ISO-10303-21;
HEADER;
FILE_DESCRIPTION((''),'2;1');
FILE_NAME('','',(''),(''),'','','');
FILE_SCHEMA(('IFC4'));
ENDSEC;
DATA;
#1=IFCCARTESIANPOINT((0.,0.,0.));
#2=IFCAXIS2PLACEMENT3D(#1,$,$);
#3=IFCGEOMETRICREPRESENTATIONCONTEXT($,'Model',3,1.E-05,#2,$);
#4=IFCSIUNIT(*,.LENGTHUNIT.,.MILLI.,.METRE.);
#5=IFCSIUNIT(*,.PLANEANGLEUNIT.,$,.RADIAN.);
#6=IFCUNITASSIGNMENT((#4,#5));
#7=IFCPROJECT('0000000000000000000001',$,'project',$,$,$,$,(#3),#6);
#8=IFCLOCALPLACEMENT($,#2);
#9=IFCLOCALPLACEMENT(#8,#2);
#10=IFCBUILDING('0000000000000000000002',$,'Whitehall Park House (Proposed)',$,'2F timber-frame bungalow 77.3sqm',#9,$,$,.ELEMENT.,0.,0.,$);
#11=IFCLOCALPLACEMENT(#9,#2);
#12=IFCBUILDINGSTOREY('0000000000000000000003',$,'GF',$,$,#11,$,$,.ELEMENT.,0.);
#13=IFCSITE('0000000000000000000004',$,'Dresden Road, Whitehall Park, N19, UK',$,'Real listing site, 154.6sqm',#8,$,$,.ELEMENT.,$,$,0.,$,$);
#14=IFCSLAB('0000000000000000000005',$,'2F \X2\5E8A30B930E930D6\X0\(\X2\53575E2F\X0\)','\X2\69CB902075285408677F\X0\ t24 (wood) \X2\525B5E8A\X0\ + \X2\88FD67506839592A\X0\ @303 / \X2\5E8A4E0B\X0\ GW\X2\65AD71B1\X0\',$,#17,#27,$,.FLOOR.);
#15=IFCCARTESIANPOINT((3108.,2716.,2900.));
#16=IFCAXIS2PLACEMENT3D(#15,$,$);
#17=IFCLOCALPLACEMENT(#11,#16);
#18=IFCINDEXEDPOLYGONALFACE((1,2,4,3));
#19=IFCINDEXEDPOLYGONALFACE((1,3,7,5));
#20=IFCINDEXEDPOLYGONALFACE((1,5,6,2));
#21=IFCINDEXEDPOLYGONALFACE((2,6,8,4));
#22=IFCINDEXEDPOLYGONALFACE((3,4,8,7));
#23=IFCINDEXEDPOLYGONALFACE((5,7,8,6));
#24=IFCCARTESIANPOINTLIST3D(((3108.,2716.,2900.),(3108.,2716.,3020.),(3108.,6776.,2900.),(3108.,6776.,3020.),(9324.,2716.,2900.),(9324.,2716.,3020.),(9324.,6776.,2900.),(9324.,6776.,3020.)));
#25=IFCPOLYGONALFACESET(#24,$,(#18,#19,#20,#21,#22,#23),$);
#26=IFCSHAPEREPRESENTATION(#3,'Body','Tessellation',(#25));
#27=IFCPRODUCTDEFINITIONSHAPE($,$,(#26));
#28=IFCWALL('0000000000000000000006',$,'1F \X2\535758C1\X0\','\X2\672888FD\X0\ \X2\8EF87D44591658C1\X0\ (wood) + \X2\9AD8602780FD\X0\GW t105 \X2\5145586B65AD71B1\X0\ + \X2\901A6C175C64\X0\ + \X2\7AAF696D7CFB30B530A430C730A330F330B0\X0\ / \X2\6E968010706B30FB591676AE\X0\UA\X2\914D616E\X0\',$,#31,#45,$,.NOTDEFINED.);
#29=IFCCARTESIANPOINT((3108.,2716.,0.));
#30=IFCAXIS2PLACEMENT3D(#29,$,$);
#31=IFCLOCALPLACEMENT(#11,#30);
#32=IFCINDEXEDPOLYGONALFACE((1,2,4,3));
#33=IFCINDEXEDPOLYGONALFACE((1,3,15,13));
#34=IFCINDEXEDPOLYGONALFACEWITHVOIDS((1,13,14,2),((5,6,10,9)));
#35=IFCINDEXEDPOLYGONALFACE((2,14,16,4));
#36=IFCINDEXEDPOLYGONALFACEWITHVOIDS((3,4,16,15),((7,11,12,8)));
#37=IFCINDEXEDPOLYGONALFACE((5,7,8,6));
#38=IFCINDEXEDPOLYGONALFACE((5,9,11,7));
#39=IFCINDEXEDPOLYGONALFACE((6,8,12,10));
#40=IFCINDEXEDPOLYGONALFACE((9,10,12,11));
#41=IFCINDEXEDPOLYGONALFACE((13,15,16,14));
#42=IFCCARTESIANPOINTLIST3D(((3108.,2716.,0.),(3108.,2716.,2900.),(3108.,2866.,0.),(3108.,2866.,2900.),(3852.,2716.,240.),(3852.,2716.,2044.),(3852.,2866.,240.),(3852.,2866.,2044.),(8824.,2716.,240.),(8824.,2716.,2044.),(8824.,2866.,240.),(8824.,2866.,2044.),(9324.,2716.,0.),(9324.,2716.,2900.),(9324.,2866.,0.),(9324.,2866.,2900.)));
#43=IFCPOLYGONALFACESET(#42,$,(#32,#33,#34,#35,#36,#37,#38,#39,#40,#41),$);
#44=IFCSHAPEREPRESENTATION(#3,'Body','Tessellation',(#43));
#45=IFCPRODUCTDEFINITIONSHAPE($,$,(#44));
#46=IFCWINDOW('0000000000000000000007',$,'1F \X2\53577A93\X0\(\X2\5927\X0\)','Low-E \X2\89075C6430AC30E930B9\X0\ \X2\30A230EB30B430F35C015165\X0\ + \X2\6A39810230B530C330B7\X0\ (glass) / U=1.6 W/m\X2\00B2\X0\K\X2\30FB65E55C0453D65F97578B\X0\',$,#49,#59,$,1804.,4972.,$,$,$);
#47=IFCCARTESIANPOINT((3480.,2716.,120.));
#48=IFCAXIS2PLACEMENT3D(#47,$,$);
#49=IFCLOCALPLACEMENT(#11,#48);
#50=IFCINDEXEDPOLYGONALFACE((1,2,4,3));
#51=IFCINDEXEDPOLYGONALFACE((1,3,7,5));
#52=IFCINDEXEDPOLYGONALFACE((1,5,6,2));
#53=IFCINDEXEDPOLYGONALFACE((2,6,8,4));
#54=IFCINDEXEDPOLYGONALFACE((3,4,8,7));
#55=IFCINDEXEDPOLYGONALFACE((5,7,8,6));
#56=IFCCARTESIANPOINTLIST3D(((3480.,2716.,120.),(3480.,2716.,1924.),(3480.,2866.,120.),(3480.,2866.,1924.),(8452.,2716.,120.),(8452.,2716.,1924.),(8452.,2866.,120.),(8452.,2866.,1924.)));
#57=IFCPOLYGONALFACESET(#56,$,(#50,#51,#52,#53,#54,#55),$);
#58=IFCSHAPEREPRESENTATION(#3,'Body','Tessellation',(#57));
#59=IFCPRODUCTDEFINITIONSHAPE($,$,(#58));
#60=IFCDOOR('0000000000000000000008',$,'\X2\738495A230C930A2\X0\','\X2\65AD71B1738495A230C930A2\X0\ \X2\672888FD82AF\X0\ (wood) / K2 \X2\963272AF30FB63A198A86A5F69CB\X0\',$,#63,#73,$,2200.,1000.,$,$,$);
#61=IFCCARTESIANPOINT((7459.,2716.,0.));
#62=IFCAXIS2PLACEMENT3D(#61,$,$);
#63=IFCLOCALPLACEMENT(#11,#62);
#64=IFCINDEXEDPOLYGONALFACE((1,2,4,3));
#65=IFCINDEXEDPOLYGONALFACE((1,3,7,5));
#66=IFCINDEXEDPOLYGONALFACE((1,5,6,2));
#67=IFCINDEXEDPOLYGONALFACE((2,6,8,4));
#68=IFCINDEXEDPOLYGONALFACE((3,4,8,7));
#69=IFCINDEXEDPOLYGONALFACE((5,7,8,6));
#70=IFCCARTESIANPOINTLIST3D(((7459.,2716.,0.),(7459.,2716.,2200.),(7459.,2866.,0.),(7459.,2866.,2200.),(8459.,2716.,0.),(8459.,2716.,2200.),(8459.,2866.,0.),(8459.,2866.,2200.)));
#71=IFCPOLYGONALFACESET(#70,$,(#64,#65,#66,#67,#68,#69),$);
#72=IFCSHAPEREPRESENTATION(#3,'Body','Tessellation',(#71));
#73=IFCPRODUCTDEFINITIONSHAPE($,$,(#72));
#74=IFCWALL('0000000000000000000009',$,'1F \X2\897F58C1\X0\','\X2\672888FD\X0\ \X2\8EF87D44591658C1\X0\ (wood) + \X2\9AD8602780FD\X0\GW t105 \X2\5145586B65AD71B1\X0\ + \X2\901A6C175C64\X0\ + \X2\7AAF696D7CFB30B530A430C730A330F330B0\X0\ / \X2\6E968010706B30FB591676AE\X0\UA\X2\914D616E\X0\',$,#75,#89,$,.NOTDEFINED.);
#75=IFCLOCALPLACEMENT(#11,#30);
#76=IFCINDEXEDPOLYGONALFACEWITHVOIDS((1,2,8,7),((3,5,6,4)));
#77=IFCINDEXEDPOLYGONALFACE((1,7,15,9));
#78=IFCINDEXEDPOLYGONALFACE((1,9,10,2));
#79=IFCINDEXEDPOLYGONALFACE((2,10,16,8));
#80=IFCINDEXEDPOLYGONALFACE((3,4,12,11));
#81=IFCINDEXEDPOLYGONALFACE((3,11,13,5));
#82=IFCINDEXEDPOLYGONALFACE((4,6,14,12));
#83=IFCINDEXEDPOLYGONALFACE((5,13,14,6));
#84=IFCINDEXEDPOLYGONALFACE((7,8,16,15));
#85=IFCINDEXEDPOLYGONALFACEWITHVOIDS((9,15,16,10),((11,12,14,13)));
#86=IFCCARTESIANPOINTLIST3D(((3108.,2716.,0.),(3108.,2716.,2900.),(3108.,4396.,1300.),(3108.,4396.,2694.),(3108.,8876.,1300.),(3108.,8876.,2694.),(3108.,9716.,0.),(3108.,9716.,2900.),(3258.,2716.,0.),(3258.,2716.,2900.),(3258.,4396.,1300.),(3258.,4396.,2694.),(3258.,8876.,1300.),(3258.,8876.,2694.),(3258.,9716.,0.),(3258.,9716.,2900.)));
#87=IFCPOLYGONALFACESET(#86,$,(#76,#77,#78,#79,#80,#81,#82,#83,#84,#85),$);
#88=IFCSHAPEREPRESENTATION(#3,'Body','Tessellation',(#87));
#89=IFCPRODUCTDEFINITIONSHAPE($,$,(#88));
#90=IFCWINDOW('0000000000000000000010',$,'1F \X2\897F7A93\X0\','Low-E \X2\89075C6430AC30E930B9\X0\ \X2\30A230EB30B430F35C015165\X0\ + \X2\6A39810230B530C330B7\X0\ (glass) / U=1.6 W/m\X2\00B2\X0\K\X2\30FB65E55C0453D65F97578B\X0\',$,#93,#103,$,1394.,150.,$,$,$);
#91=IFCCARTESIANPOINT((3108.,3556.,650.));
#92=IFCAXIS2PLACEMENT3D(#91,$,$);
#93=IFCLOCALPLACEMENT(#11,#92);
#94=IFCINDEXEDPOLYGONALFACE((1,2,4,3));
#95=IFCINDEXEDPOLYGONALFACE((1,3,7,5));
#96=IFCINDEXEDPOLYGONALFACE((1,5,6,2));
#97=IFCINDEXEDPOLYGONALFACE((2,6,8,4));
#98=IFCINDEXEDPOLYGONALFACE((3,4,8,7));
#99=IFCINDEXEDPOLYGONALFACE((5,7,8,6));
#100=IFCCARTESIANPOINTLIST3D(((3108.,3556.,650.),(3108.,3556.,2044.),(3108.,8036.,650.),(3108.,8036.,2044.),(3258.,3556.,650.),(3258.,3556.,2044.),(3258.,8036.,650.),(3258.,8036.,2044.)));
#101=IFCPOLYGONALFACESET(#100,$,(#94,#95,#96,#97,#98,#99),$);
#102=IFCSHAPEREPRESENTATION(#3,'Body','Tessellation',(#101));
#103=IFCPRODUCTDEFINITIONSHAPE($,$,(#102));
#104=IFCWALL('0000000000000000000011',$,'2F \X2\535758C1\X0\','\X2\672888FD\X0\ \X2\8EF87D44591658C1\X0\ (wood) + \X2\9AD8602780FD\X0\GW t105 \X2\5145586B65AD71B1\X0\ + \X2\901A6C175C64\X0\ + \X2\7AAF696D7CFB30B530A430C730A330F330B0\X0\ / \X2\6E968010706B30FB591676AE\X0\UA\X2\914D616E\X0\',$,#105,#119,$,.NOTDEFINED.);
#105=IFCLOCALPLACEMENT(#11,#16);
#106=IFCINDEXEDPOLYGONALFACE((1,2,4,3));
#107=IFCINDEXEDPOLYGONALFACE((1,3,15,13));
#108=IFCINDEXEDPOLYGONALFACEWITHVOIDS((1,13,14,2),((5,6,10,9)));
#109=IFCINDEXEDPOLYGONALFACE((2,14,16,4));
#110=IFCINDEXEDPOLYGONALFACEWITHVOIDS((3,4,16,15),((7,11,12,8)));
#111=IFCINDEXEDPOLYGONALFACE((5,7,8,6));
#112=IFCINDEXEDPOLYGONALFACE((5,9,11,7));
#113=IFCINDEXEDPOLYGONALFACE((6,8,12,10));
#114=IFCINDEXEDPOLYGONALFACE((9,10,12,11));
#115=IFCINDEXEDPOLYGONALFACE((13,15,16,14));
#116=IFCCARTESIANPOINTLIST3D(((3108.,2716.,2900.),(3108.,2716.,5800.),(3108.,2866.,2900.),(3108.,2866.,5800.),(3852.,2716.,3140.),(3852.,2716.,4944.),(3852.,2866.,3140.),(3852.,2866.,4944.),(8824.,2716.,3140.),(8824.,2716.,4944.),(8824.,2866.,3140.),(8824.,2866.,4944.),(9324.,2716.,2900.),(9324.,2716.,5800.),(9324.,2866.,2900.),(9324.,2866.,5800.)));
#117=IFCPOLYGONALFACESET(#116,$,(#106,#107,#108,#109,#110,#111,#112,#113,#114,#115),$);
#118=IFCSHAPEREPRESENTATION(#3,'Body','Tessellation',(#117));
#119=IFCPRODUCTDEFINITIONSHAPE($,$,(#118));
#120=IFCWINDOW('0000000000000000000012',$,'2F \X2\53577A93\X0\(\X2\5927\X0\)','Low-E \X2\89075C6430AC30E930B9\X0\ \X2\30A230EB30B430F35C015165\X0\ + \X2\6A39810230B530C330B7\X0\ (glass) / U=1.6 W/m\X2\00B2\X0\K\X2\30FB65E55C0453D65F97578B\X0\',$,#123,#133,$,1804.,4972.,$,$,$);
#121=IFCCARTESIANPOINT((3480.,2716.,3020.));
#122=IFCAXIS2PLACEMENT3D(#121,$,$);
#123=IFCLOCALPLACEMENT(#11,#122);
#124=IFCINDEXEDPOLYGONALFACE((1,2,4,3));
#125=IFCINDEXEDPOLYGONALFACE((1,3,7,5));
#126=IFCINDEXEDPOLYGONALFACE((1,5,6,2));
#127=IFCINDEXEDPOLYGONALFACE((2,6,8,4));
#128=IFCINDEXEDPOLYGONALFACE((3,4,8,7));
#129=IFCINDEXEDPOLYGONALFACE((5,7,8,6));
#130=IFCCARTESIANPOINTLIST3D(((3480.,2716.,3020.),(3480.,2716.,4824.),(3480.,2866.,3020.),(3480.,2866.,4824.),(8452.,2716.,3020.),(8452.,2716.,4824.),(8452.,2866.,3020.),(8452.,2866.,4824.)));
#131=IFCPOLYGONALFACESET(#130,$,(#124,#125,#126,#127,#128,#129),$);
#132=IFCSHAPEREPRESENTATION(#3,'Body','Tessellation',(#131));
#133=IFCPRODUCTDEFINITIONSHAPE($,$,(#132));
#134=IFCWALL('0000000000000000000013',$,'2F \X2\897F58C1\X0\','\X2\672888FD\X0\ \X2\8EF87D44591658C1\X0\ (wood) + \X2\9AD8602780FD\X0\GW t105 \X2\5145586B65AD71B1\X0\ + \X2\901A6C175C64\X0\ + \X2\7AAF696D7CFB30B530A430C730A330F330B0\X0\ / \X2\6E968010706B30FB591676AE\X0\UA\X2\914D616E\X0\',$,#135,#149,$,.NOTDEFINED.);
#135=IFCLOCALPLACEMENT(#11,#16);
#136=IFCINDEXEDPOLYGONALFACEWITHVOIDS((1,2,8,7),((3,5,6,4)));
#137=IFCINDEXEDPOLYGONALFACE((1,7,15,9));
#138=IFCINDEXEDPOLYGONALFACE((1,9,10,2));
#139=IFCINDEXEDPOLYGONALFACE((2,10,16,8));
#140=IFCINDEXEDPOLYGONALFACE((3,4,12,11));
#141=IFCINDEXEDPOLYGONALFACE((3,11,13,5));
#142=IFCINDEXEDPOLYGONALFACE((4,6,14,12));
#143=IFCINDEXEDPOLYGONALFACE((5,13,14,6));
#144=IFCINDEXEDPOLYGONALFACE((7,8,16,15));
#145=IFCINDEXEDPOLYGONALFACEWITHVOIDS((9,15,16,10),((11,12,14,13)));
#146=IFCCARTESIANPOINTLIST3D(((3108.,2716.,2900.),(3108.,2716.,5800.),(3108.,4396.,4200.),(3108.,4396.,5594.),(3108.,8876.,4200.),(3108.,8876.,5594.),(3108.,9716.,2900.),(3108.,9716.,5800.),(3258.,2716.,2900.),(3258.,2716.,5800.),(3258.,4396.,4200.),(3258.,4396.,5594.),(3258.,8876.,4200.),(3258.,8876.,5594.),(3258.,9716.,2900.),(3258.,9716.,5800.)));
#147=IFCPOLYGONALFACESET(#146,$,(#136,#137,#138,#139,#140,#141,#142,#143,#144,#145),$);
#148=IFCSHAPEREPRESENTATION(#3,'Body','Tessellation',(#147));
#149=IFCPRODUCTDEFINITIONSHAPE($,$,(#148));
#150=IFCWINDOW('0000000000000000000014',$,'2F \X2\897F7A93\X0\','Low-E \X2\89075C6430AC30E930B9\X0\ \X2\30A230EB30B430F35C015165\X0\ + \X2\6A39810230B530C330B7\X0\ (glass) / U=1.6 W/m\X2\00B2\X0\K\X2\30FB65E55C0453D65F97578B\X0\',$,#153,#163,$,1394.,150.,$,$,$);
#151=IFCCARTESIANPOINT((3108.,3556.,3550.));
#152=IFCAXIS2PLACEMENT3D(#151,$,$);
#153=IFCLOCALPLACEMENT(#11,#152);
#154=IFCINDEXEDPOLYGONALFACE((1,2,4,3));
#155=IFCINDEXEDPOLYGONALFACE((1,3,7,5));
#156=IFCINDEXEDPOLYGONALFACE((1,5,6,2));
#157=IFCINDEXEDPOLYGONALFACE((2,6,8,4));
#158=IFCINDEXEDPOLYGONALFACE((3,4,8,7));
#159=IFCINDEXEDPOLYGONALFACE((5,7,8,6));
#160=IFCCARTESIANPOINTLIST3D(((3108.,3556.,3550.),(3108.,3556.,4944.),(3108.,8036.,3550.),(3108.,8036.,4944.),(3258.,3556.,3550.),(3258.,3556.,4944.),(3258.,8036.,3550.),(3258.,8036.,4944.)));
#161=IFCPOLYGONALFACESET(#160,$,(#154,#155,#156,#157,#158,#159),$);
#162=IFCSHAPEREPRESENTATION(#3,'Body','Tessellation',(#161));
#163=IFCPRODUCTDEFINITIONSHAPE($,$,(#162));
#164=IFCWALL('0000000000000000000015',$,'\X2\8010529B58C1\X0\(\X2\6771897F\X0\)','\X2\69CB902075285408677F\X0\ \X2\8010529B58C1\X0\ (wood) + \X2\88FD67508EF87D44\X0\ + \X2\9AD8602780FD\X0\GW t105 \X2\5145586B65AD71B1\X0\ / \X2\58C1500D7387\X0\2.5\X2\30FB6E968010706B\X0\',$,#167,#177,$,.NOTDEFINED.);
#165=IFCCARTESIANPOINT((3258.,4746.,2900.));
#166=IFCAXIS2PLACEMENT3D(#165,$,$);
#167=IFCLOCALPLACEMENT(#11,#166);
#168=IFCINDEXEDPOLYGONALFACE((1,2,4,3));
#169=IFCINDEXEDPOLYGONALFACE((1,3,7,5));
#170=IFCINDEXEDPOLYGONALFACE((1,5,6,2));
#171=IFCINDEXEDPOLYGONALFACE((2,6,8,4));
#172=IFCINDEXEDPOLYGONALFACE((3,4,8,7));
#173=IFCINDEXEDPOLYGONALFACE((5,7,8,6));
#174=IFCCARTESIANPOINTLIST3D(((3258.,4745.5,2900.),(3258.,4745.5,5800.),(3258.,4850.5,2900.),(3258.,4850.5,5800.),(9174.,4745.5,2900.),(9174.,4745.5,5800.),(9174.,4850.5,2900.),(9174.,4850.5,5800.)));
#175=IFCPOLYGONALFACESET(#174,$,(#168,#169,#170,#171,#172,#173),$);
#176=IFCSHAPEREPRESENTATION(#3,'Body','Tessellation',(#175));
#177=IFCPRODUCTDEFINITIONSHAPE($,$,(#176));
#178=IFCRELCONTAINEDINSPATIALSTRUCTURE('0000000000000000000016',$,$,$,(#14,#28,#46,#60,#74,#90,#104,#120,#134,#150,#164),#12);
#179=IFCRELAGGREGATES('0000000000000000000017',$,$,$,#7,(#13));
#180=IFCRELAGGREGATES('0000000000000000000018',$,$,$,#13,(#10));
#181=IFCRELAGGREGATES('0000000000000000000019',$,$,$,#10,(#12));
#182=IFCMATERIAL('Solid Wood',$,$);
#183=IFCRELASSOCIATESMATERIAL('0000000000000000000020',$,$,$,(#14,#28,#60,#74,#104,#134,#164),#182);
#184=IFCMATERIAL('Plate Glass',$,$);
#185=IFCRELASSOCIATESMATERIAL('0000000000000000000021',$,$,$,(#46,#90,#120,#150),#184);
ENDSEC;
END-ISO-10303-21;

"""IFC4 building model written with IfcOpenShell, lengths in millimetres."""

from ifc_helpers import new_model, si_unit, frame, frame_2d, origin, place, context, project, spatial, rectangle, extrude, material, element, fill, save


model = new_model("IFC4")

# Units and contexts
model_context = context("Model", 3, precision=1e-05, world=origin())
ifc_project = project(units=[si_unit("LENGTHUNIT", "METRE", prefix="MILLI"), si_unit("PLANEANGLEUNIT", "RADIAN")], contexts=[model_context])

# Site, building, storey
site_placement = place(None, origin())
site = spatial("IfcSite", under=ifc_project, at=site_placement, Name="Dresden Road, Whitehall Park, N19, UK", ObjectType="Real listing site, 154.6sqm", CompositionType="ELEMENT", RefElevation=0.0)
building_placement = place(site_placement, origin())
building = spatial("IfcBuilding", under=site, at=building_placement, Name="Whitehall Park House (Proposed)", ObjectType="2F timber-frame bungalow 77.3sqm", CompositionType="ELEMENT", ElevationOfRefHeight=0.0, ElevationOfTerrain=0.0)
storey_placement = place(building_placement, origin())
storey = spatial("IfcBuildingStorey", under=building, at=storey_placement, Name="GF", CompositionType="ELEMENT", Elevation=0.0)

# Slab
ifc_material_1 = material(Name="Solid Wood")
slab_1_placement = place(storey_placement, frame((3108.0, 2716.0, 2900.0)))
element("IfcSlab", 1, at=slab_1_placement, inside=storey, material=ifc_material_1, Name="2F 床スラブ(南帯)", Description="構造用合板 t24 (wood) 剛床 + 製材根太 @303 / 床下 GW断熱", PredefinedType="FLOOR", context=model_context, shape_type="SweptSolid", body=[
    extrude(rectangle(XDim=6216.0, YDim=4060.0, at=frame_2d((3108.0, 2030.0))), frame((3108.0, 2716.0, 2900.0)), (0.0, 0.0, 1.0), 120.0),
])

# Wall, openings, window, door
wall_1_placement = place(storey_placement, frame((3108.0, 2716.0, 0.0)))
wall_1 = element("IfcWall", 2, at=wall_1_placement, inside=storey, material=ifc_material_1, Name="1F 南壁", Description="木製 軸組外壁 (wood) + 高性能GW t105 充填断熱 + 通気層 + 窯業系サイディング / 準耐火・外皮UA配慮", PredefinedType="NOTDEFINED", context=model_context, shape_type="SweptSolid", body=[
    extrude(rectangle(XDim=6216.0, YDim=150.0, at=frame_2d((3108.0, 75.0))), frame((3108.0, 2716.0, 0.0)), (0.0, 0.0, 1.0), 2900.0),
])
opening_1_placement = place(storey_placement, frame((3480.0, 2716.0, 120.0)))
opening_1 = element("IfcOpeningElement", 3, at=opening_1_placement, cuts=wall_1, PredefinedType="NOTDEFINED", context=model_context, shape_type="SweptSolid", body=[
    extrude(rectangle(XDim=4972.0, YDim=150.0, at=frame_2d((2486.0, 75.0))), frame((3480.0, 2716.0, 120.0)), (0.0, 0.0, 1.0), 1804.0),
])
opening_2_placement = place(storey_placement, frame((7459.0, 2716.0, 0.0)))
opening_2 = element("IfcOpeningElement", 4, at=opening_2_placement, cuts=wall_1, PredefinedType="NOTDEFINED", context=model_context, shape_type="SweptSolid", body=[
    extrude(rectangle(XDim=1000.0, YDim=150.0, at=frame_2d((500.0, 75.0))), frame((7459.0, 2716.0, 0.0)), (0.0, 0.0, 1.0), 2200.0),
])
ifc_material_2 = material(Name="Plate Glass")
window_1_placement = place(storey_placement, frame((3480.0, 2716.0, 120.0)))
window_1 = element("IfcWindow", 5, at=window_1_placement, inside=storey, material=ifc_material_2, Name="1F 南窓(大)", Description="Low-E 複層ガラス アルゴン封入 + 樹脂サッシ (glass) / U=1.6 W/m²K・日射取得型", OverallHeight=1804.0, OverallWidth=4972.0, context=model_context, shape_type="SweptSolid", body=[
    extrude(rectangle(XDim=4972.0, YDim=150.0, at=frame_2d((2486.0, 75.0))), frame((3480.0, 2716.0, 120.0)), (0.0, 0.0, 1.0), 1804.0),
])
fill(opening_1, window_1)
door_placement = place(storey_placement, frame((7459.0, 2716.0, 0.0)))
door = element("IfcDoor", 6, at=door_placement, inside=storey, material=ifc_material_1, Name="玄関ドア", Description="断熱玄関ドア 木製芯 (wood) / K2 防犯・採風機構", OverallHeight=2200.0, OverallWidth=1000.0, context=model_context, shape_type="SweptSolid", body=[
    extrude(rectangle(XDim=1000.0, YDim=150.0, at=frame_2d((500.0, 75.0))), frame((7459.0, 2716.0, 0.0)), (0.0, 0.0, 1.0), 2200.0),
])
fill(opening_2, door)

# Wall, opening, window
wall_2_placement = place(storey_placement, frame((3108.0, 2716.0, 0.0)))
wall_2 = element("IfcWall", 7, at=wall_2_placement, inside=storey, material=ifc_material_1, Name="1F 西壁", Description="木製 軸組外壁 (wood) + 高性能GW t105 充填断熱 + 通気層 + 窯業系サイディング / 準耐火・外皮UA配慮", PredefinedType="NOTDEFINED", context=model_context, shape_type="SweptSolid", body=[
    extrude(rectangle(XDim=150.0, YDim=7000.0, at=frame_2d((75.0, 3500.0))), frame((3108.0, 2716.0, 0.0)), (0.0, 0.0, 1.0), 2900.0),
])
opening_3_placement = place(storey_placement, frame((3108.0, 3556.0, 650.0)))
opening_3 = element("IfcOpeningElement", 8, at=opening_3_placement, cuts=wall_2, PredefinedType="NOTDEFINED", context=model_context, shape_type="SweptSolid", body=[
    extrude(rectangle(XDim=150.0, YDim=4480.0, at=frame_2d((75.0, 2240.0))), frame((3108.0, 3556.0, 650.0)), (0.0, 0.0, 1.0), 1394.0),
])
window_2_placement = place(storey_placement, frame((3108.0, 3556.0, 650.0)))
window_2 = element("IfcWindow", 9, at=window_2_placement, inside=storey, material=ifc_material_2, Name="1F 西窓", Description="Low-E 複層ガラス アルゴン封入 + 樹脂サッシ (glass) / U=1.6 W/m²K・日射取得型", OverallHeight=1394.0, OverallWidth=150.0, context=model_context, shape_type="SweptSolid", body=[
    extrude(rectangle(XDim=150.0, YDim=4480.0, at=frame_2d((75.0, 2240.0))), frame((3108.0, 3556.0, 650.0)), (0.0, 0.0, 1.0), 1394.0),
])
fill(opening_3, window_2)

# Walls, openings, windows
wall_3_placement = place(storey_placement, frame((3108.0, 2716.0, 2900.0)))
wall_3 = element("IfcWall", 10, at=wall_3_placement, inside=storey, material=ifc_material_1, Name="2F 南壁", Description="木製 軸組外壁 (wood) + 高性能GW t105 充填断熱 + 通気層 + 窯業系サイディング / 準耐火・外皮UA配慮", PredefinedType="NOTDEFINED", context=model_context, shape_type="SweptSolid", body=[
    extrude(rectangle(XDim=6216.0, YDim=150.0, at=frame_2d((3108.0, 75.0))), frame((3108.0, 2716.0, 2900.0)), (0.0, 0.0, 1.0), 2900.0),
])
opening_4_placement = place(storey_placement, frame((3480.0, 2716.0, 3020.0)))
opening_4 = element("IfcOpeningElement", 11, at=opening_4_placement, cuts=wall_3, PredefinedType="NOTDEFINED", context=model_context, shape_type="SweptSolid", body=[
    extrude(rectangle(XDim=4972.0, YDim=150.0, at=frame_2d((2486.0, 75.0))), frame((3480.0, 2716.0, 3020.0)), (0.0, 0.0, 1.0), 1804.0),
])
window_3_placement = place(storey_placement, frame((3480.0, 2716.0, 3020.0)))
window_3 = element("IfcWindow", 12, at=window_3_placement, inside=storey, material=ifc_material_2, Name="2F 南窓(大)", Description="Low-E 複層ガラス アルゴン封入 + 樹脂サッシ (glass) / U=1.6 W/m²K・日射取得型", OverallHeight=1804.0, OverallWidth=4972.0, context=model_context, shape_type="SweptSolid", body=[
    extrude(rectangle(XDim=4972.0, YDim=150.0, at=frame_2d((2486.0, 75.0))), frame((3480.0, 2716.0, 3020.0)), (0.0, 0.0, 1.0), 1804.0),
])
fill(opening_4, window_3)
wall_4_placement = place(storey_placement, frame((3108.0, 2716.0, 2900.0)))
wall_4 = element("IfcWall", 13, at=wall_4_placement, inside=storey, material=ifc_material_1, Name="2F 西壁", Description="木製 軸組外壁 (wood) + 高性能GW t105 充填断熱 + 通気層 + 窯業系サイディング / 準耐火・外皮UA配慮", PredefinedType="NOTDEFINED", context=model_context, shape_type="SweptSolid", body=[
    extrude(rectangle(XDim=150.0, YDim=7000.0, at=frame_2d((75.0, 3500.0))), frame((3108.0, 2716.0, 2900.0)), (0.0, 0.0, 1.0), 2900.0),
])
opening_5_placement = place(storey_placement, frame((3108.0, 3556.0, 3550.0)))
opening_5 = element("IfcOpeningElement", 14, at=opening_5_placement, cuts=wall_4, PredefinedType="NOTDEFINED", context=model_context, shape_type="SweptSolid", body=[
    extrude(rectangle(XDim=150.0, YDim=4480.0, at=frame_2d((75.0, 2240.0))), frame((3108.0, 3556.0, 3550.0)), (0.0, 0.0, 1.0), 1394.0),
])
window_4_placement = place(storey_placement, frame((3108.0, 3556.0, 3550.0)))
window_4 = element("IfcWindow", 15, at=window_4_placement, inside=storey, material=ifc_material_2, Name="2F 西窓", Description="Low-E 複層ガラス アルゴン封入 + 樹脂サッシ (glass) / U=1.6 W/m²K・日射取得型", OverallHeight=1394.0, OverallWidth=150.0, context=model_context, shape_type="SweptSolid", body=[
    extrude(rectangle(XDim=150.0, YDim=4480.0, at=frame_2d((75.0, 2240.0))), frame((3108.0, 3556.0, 3550.0)), (0.0, 0.0, 1.0), 1394.0),
])
fill(opening_5, window_4)

# Wall
wall_5_placement = place(storey_placement, frame((3258.0, 4746.0, 2900.0)))
element("IfcWall", 16, at=wall_5_placement, inside=storey, material=ifc_material_1, Name="耐力壁(東西)", Description="構造用合板 耐力壁 (wood) + 製材軸組 + 高性能GW t105 充填断熱 / 壁倍率2.5・準耐火", PredefinedType="NOTDEFINED", context=model_context, shape_type="SweptSolid", body=[
    extrude(rectangle(XDim=5916.0, YDim=105.0, at=frame_2d((2958.0, 52.0))), frame((3258.0, 4746.0, 2900.0)), (0.0, 0.0, 1.0), 2900.0),
])

save(model, "model.ifc")
